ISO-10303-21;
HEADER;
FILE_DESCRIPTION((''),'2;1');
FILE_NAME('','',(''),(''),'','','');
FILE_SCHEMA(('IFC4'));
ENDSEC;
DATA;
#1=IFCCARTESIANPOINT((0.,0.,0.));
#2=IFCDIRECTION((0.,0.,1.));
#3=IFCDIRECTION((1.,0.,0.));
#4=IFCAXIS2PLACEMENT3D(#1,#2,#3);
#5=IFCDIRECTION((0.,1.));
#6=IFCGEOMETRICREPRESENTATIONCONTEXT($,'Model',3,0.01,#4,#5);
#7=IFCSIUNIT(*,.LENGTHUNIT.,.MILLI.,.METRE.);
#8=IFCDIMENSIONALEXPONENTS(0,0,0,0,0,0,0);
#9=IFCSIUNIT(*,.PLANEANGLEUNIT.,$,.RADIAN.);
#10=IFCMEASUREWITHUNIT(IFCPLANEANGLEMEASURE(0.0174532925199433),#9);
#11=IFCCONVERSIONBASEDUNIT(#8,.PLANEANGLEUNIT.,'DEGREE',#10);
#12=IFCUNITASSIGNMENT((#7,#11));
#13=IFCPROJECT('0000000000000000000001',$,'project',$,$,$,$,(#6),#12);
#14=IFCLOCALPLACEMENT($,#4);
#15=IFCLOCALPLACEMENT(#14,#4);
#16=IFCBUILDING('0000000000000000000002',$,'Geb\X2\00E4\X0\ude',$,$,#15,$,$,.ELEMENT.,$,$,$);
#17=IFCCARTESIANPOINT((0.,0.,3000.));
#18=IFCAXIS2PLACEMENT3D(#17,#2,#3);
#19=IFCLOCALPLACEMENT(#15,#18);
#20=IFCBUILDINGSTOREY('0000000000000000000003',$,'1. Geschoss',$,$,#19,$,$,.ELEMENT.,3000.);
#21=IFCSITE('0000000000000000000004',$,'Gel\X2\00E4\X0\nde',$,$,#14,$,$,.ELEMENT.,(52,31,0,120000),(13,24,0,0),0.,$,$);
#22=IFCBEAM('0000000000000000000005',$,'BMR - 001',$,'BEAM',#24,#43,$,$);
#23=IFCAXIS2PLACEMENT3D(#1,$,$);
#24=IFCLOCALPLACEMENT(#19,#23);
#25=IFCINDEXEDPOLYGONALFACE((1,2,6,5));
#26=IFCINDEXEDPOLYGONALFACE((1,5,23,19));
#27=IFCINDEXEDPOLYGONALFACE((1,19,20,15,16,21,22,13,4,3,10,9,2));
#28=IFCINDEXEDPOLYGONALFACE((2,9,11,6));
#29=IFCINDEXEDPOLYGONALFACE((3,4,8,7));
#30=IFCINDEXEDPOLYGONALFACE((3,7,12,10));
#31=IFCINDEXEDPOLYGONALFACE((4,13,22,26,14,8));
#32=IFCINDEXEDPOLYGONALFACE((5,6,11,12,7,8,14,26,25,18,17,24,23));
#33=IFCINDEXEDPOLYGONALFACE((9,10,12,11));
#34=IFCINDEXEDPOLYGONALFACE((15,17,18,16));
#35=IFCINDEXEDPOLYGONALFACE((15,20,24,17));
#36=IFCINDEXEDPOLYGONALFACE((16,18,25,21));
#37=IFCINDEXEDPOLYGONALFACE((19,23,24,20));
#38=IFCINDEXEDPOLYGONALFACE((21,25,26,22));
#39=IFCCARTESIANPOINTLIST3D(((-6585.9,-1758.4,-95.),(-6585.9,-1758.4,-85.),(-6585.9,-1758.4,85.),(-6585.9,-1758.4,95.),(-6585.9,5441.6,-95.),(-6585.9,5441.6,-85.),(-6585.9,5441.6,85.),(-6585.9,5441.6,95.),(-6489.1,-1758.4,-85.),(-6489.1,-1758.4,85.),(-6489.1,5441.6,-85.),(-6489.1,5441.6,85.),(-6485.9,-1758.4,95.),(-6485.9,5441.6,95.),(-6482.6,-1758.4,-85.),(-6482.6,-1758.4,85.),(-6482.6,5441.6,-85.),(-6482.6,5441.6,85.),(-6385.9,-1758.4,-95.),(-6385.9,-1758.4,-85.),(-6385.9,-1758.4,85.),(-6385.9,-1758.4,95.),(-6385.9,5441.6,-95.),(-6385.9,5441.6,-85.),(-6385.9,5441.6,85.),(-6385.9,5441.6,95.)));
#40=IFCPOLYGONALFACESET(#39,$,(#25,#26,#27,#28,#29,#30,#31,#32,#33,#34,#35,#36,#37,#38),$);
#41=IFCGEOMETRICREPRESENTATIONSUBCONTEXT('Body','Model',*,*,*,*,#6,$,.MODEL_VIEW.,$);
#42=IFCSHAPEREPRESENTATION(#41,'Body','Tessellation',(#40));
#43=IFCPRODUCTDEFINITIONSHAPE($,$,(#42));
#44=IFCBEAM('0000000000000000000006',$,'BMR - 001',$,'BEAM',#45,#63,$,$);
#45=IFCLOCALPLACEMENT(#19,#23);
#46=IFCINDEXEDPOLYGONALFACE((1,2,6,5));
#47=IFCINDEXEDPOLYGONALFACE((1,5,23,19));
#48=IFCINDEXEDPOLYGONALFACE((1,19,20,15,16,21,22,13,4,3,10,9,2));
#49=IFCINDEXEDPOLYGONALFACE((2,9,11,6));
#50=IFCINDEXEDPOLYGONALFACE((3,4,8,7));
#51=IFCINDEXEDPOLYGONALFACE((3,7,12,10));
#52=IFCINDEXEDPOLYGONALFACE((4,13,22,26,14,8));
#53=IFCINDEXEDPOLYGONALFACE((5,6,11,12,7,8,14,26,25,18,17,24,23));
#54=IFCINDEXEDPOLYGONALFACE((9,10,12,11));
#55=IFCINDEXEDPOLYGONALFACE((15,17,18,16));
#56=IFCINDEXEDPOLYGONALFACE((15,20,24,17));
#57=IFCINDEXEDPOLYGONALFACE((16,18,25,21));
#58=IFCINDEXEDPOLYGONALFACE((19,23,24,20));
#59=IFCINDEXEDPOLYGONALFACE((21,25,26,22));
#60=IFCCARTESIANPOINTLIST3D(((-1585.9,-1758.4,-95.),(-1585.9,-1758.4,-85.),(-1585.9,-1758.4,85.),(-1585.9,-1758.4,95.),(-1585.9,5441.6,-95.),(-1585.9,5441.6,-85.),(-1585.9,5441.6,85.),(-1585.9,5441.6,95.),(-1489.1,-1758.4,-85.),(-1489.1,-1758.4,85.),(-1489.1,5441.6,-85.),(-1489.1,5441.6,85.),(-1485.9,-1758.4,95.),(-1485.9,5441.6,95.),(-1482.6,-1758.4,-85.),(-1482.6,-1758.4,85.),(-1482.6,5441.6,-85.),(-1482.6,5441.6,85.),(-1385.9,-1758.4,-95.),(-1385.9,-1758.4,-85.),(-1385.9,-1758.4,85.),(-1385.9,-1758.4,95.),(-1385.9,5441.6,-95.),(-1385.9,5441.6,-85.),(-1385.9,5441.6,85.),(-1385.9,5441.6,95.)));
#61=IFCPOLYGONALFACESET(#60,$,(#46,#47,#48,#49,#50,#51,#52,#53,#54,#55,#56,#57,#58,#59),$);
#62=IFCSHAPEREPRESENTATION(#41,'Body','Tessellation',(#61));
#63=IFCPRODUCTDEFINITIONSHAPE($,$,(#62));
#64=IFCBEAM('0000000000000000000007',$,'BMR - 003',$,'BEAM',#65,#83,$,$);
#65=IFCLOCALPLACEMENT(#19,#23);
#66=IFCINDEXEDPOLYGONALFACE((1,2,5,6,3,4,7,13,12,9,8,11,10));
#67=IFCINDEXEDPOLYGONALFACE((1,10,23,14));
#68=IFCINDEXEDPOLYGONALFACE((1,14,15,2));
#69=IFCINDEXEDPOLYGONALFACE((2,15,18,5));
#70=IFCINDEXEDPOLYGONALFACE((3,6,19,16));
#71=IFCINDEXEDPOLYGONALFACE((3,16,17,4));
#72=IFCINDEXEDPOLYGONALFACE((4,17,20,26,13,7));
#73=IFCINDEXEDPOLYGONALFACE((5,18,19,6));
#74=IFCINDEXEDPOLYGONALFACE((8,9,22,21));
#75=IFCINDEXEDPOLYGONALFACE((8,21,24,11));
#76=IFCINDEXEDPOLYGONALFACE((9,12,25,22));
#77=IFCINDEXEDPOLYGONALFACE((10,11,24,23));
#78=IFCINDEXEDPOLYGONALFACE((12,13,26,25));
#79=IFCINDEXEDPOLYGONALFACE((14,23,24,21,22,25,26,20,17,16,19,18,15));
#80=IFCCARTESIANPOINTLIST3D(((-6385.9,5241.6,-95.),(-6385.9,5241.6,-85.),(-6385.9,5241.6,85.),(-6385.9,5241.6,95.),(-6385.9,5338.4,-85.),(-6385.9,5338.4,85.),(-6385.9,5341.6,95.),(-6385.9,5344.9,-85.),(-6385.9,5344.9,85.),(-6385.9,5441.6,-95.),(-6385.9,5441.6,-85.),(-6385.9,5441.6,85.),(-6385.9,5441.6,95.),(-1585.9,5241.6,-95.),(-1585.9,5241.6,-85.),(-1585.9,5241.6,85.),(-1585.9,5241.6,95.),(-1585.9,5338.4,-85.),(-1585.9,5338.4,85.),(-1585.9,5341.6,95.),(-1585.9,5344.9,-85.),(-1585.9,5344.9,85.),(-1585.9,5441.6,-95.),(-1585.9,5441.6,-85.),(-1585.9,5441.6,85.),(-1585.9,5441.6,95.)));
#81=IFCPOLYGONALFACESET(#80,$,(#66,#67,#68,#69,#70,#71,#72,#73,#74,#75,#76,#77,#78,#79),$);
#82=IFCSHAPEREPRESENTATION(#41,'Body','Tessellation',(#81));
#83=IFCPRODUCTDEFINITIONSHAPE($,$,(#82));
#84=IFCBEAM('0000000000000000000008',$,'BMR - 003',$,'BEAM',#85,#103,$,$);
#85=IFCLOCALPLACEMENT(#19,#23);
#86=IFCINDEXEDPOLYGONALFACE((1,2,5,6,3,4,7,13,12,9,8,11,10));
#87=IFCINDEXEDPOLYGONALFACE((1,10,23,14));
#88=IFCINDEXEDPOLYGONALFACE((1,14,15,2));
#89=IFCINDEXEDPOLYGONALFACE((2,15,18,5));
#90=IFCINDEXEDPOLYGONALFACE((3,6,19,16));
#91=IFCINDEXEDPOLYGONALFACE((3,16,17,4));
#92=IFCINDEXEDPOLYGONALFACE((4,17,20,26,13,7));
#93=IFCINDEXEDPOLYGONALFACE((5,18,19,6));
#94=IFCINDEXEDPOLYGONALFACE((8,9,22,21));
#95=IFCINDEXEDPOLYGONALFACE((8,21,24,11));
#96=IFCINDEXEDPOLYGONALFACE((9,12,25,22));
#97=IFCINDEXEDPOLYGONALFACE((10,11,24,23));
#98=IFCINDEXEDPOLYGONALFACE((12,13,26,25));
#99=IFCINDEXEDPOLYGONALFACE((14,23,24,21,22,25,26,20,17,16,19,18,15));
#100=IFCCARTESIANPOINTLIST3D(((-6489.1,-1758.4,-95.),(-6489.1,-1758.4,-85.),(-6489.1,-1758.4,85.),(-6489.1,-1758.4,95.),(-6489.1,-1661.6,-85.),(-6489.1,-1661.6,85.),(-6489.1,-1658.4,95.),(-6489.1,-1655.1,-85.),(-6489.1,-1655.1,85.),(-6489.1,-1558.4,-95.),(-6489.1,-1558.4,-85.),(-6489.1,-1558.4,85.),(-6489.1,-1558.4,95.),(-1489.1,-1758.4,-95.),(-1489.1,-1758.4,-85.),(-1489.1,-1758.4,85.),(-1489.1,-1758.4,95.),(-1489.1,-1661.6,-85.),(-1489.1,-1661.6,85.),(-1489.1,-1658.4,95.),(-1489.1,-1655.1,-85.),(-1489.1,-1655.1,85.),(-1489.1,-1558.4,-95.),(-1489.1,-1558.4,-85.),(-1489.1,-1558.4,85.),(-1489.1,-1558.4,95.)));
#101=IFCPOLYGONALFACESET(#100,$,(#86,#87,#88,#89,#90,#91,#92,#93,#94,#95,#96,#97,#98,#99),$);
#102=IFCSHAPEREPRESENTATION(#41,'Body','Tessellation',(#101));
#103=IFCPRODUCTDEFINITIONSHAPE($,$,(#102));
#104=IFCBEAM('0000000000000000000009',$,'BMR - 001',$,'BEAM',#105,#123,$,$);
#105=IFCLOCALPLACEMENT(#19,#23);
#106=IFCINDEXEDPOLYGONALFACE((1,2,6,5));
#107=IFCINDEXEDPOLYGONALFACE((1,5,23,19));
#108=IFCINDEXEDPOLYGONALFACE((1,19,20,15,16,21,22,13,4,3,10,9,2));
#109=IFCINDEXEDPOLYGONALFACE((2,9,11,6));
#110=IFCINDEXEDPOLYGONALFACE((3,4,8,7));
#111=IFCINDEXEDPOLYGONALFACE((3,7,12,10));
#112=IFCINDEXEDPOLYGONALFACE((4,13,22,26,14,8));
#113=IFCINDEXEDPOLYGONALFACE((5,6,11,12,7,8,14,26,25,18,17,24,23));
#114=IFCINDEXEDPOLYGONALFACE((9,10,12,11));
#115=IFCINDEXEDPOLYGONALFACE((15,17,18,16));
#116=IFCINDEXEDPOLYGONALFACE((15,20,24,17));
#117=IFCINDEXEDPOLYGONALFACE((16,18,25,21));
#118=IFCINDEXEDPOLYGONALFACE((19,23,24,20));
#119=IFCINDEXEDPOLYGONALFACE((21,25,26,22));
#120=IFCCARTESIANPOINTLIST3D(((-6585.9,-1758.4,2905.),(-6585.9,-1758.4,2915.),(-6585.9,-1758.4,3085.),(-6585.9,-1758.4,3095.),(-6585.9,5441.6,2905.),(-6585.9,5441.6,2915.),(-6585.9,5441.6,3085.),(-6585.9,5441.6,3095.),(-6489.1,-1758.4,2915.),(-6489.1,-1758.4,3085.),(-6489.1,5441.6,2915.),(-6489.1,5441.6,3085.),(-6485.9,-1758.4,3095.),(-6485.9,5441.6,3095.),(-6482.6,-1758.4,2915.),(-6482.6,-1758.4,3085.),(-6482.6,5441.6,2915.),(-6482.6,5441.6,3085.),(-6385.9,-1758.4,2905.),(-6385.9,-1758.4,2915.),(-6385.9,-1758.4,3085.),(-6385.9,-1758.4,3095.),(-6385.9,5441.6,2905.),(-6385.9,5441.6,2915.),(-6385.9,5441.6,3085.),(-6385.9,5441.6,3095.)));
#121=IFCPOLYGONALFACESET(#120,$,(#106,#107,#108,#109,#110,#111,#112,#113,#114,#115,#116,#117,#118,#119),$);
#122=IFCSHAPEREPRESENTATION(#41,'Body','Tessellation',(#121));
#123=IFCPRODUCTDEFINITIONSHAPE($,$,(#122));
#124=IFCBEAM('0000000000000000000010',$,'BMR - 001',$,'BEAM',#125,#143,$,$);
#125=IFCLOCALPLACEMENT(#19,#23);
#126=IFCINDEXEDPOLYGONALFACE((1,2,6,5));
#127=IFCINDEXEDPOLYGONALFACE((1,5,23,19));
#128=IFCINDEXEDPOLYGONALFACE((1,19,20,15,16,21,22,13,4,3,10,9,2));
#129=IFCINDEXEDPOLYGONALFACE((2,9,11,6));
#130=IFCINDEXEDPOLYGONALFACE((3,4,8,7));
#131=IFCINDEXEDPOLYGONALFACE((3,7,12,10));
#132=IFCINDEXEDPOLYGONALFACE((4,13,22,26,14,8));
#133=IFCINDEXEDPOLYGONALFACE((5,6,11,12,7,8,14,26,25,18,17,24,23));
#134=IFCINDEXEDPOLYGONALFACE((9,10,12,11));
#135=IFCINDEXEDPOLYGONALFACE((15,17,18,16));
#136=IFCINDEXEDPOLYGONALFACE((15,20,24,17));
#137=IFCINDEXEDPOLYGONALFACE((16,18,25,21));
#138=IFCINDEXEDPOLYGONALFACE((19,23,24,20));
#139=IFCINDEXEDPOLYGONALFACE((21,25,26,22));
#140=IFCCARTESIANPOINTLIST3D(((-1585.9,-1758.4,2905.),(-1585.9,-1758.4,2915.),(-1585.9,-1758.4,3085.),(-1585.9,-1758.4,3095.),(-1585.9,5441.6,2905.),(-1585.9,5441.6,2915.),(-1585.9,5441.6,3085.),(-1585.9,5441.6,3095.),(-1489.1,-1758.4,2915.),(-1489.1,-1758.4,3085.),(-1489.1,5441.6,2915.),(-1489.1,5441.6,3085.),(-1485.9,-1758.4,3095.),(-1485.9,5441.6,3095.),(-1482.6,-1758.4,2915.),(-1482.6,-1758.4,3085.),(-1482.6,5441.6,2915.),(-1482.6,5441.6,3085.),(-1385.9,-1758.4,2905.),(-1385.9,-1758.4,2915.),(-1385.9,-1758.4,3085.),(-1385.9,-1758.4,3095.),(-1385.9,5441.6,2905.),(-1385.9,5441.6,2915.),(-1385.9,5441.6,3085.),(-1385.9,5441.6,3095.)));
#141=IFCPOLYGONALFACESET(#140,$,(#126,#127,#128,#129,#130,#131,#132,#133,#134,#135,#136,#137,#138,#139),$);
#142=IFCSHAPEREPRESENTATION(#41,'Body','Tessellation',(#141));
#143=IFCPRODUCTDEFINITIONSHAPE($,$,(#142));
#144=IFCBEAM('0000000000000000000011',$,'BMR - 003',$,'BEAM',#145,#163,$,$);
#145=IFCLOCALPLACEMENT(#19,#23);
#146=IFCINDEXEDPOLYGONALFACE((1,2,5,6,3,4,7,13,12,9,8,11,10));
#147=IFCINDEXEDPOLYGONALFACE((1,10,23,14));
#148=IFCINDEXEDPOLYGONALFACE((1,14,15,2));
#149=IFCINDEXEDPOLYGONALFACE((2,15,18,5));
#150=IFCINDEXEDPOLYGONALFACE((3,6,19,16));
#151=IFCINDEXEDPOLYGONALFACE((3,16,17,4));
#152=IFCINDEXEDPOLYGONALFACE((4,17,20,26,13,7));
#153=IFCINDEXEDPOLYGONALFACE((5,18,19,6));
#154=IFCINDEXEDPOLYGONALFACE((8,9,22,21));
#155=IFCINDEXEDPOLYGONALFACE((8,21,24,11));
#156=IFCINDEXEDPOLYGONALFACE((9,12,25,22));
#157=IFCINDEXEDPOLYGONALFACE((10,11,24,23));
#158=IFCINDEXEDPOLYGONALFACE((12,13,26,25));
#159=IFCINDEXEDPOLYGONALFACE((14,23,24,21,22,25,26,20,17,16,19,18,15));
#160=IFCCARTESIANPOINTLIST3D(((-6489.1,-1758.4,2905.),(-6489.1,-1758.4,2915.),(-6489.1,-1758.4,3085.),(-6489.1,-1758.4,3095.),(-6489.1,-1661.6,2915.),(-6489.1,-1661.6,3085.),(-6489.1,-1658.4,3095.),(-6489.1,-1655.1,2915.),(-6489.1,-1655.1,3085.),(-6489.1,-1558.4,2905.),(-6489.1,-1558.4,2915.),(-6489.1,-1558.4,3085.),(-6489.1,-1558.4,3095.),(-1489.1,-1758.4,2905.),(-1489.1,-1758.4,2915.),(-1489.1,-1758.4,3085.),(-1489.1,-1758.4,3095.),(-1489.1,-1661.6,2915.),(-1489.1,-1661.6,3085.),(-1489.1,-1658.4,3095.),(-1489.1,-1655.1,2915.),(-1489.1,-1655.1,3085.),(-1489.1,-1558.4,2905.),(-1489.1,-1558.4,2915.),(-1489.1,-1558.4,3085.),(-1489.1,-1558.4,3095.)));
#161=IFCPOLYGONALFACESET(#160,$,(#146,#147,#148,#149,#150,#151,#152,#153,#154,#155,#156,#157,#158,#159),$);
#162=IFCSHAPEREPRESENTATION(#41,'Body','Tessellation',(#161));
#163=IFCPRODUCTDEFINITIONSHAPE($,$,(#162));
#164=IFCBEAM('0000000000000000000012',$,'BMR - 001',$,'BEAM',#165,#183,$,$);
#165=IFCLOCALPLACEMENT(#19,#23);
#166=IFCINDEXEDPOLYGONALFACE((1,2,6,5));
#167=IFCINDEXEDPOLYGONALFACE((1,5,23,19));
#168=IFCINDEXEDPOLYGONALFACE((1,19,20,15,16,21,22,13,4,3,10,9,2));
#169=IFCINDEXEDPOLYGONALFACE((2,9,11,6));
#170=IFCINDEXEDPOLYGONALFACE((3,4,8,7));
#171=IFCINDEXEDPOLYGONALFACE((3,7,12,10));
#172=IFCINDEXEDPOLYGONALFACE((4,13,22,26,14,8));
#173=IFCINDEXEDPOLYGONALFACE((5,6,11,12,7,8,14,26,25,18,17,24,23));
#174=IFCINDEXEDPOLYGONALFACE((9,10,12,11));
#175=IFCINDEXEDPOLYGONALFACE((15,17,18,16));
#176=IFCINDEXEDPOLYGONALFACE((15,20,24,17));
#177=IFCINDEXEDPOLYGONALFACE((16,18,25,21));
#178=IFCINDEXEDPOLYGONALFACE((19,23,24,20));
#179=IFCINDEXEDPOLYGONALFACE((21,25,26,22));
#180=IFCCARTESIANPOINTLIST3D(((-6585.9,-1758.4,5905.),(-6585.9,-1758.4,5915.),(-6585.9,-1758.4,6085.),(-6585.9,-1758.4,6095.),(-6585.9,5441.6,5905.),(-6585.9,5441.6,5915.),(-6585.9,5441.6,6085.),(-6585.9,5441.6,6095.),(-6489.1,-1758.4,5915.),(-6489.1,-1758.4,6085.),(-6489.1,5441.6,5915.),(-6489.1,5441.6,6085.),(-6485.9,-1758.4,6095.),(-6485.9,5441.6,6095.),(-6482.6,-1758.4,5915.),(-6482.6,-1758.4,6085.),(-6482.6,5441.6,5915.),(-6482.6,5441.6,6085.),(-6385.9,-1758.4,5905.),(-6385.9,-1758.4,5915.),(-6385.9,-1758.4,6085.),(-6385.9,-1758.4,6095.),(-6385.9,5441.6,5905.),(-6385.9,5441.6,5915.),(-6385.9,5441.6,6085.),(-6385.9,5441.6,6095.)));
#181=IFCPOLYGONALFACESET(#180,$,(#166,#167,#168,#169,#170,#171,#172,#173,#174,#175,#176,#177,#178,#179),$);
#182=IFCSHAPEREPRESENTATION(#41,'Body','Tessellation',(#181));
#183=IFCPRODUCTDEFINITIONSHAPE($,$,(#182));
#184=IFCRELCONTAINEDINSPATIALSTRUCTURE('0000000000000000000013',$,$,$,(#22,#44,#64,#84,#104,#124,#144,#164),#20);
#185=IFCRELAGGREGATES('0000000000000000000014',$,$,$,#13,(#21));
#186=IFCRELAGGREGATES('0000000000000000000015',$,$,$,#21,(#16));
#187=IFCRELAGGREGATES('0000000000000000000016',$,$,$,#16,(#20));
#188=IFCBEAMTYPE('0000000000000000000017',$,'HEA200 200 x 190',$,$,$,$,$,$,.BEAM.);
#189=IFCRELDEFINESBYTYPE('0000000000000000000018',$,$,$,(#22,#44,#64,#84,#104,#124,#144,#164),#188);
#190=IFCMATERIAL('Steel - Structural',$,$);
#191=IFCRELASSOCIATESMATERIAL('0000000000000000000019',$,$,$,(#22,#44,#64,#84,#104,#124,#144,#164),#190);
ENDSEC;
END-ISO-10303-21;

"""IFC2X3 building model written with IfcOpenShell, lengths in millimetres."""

from ifc_helpers import new_model, entity, si_unit, converted_unit, direction, frame, origin_with_axes, place, context, subcontext, project, spatial, polyline, outline, extrude, material, type_object, element, save


model = new_model("IFC2X3")

# Units and contexts
model_context = context("Model", 3, precision=0.01, world=origin_with_axes(), true_north=direction((0.0, 1.0)))
body_context = subcontext(model_context, "Body", "Model", "MODEL_VIEW")
ifc_project = project(units=[si_unit("LENGTHUNIT", "METRE", prefix="MILLI"), converted_unit("PLANEANGLEUNIT", "DEGREE", entity("IfcPlaneAngleMeasure", 0.0174532925199433), si_unit("PLANEANGLEUNIT", "RADIAN"), dimensions=[0, 0, 0, 0, 0, 0, 0])], contexts=[model_context])

# Site, building, storey
site_placement = place(None, origin_with_axes())
site = spatial("IfcSite", under=ifc_project, at=site_placement, Name="Gelände", CompositionType="ELEMENT", RefLatitude=(52, 31, 0, 120000), RefLongitude=(13, 24, 0, 0), RefElevation=0.0)
building_placement = place(site_placement, origin_with_axes())
building = spatial("IfcBuilding", under=site, at=building_placement, Name="Gebäude", CompositionType="ELEMENT")
storey_placement = place(building_placement, frame((0.0, 0.0, 3000.0), z_axis=(0.0, 0.0, 1.0), x_axis=(1.0, 0.0, 0.0)))
storey = spatial("IfcBuildingStorey", under=building, at=storey_placement, Name="1. Geschoss", CompositionType="ELEMENT", Elevation=3000.0)

# Beams
ifc_material = material(Name="Steel - Structural")
beam_type = type_object("IfcBeamType", Name="HEA200 200 x 190", PredefinedType="BEAM")
for number, where, z_axis, x_axis, name in (
    (1, (-6485.9, -1758.4, 0.0), (0.0, 0.0, 1.0), (1.0, 0.0, 0.0), "BMR - 001"),
    (2, (-1485.9, -1758.4, 0.0), (0.0, 0.0, 1.0), (1.0, 0.0, 0.0), "BMR - 001"),
):
    element("IfcBeam", number, at=place(storey_placement, frame(where, z_axis=z_axis, x_axis=x_axis)), inside=storey, type_object=beam_type, material=ifc_material, Name=name, ObjectType="BEAM", context=body_context, shape_type="SweptSolid", body=[
        extrude(outline(polyline([(0.0, 95.0), (-100.0, 95.0), (-100.0, 85.0), (-3.2, 85.0), (-3.2, -85.0), (-100.0, -85.0), (-100.0, -95.0), (100.0, -95.0), (100.0, -85.0), (3.2, -85.0), (3.2, 85.0), (100.0, 85.0), (100.0, 95.0), (0.0, 95.0)])), frame((0.0, 7200.0, 0.0), z_axis=(0.0, -1.0, 0.0), x_axis=(1.0, 0.0, 0.0)), (0.0, 0.0, 1.0), 7200.0),
    ])
beam_1_placement = place(storey_placement, frame((-6385.9, 5341.6, 0.0), z_axis=(0.0, 0.0, 1.0), x_axis=(0.0, -1.0, 0.0)))
element("IfcBeam", 3, at=beam_1_placement, inside=storey, type_object=beam_type, material=ifc_material, Name="BMR - 003", ObjectType="BEAM", context=body_context, shape_type="SweptSolid", body=[
    extrude(outline(polyline([(0.0, 95.0), (-100.0, 95.0), (-100.0, 85.0), (-3.2, 85.0), (-3.2, -85.0), (-100.0, -85.0), (-100.0, -95.0), (100.0, -95.0), (100.0, -85.0), (3.2, -85.0), (3.2, 85.0), (100.0, 85.0), (100.0, 95.0), (0.0, 95.0)])), frame((0.0, 4800.0, 0.0), z_axis=(0.0, -1.0, 0.0), x_axis=(1.0, 0.0, 0.0)), (0.0, 0.0, 1.0), 4800.0),
])
beam_2_placement = place(storey_placement, frame((-6489.1, -1658.4, 0.0), z_axis=(0.0, 0.0, 1.0), x_axis=(0.0, -1.0, 0.0)))
element("IfcBeam", 4, at=beam_2_placement, inside=storey, type_object=beam_type, material=ifc_material, Name="BMR - 003", ObjectType="BEAM", context=body_context, shape_type="SweptSolid", body=[
    extrude(outline(polyline([(0.0, 95.0), (-100.0, 95.0), (-100.0, 85.0), (-3.2, 85.0), (-3.2, -85.0), (-100.0, -85.0), (-100.0, -95.0), (100.0, -95.0), (100.0, -85.0), (3.2, -85.0), (3.2, 85.0), (100.0, 85.0), (100.0, 95.0), (0.0, 95.0)])), frame((0.0, 5000.0, 0.0), z_axis=(0.0, -1.0, 0.0), x_axis=(1.0, 0.0, 0.0)), (0.0, 0.0, 1.0), 5000.0),
])
for number, where, z_axis, x_axis, name in (
    (5, (-6485.9, -1758.4, 3000.0), (0.0, 0.0, 1.0), (1.0, 0.0, 0.0), "BMR - 001"),
    (6, (-1485.9, -1758.4, 3000.0), (0.0, 0.0, 1.0), (1.0, 0.0, 0.0), "BMR - 001"),
):
    element("IfcBeam", number, at=place(storey_placement, frame(where, z_axis=z_axis, x_axis=x_axis)), inside=storey, type_object=beam_type, material=ifc_material, Name=name, ObjectType="BEAM", context=body_context, shape_type="SweptSolid", body=[
        extrude(outline(polyline([(0.0, 95.0), (-100.0, 95.0), (-100.0, 85.0), (-3.2, 85.0), (-3.2, -85.0), (-100.0, -85.0), (-100.0, -95.0), (100.0, -95.0), (100.0, -85.0), (3.2, -85.0), (3.2, 85.0), (100.0, 85.0), (100.0, 95.0), (0.0, 95.0)])), frame((0.0, 7200.0, 0.0), z_axis=(0.0, -1.0, 0.0), x_axis=(1.0, 0.0, 0.0)), (0.0, 0.0, 1.0), 7200.0),
    ])
beam_3_placement = place(storey_placement, frame((-6489.1, -1658.4, 3000.0), z_axis=(0.0, 0.0, 1.0), x_axis=(0.0, -1.0, 0.0)))
element("IfcBeam", 7, at=beam_3_placement, inside=storey, type_object=beam_type, material=ifc_material, Name="BMR - 003", ObjectType="BEAM", context=body_context, shape_type="SweptSolid", body=[
    extrude(outline(polyline([(0.0, 95.0), (-100.0, 95.0), (-100.0, 85.0), (-3.2, 85.0), (-3.2, -85.0), (-100.0, -85.0), (-100.0, -95.0), (100.0, -95.0), (100.0, -85.0), (3.2, -85.0), (3.2, 85.0), (100.0, 85.0), (100.0, 95.0), (0.0, 95.0)])), frame((0.0, 5000.0, 0.0), z_axis=(0.0, -1.0, 0.0), x_axis=(1.0, 0.0, 0.0)), (0.0, 0.0, 1.0), 5000.0),
])
for number, where, z_axis, x_axis, name in (
    (8, (-6485.9, -1758.4, 6000.0), (0.0, 0.0, 1.0), (1.0, 0.0, 0.0), "BMR - 001"),
):
    element("IfcBeam", number, at=place(storey_placement, frame(where, z_axis=z_axis, x_axis=x_axis)), inside=storey, type_object=beam_type, material=ifc_material, Name=name, ObjectType="BEAM", context=body_context, shape_type="SweptSolid", body=[
        extrude(outline(polyline([(0.0, 95.0), (-100.0, 95.0), (-100.0, 85.0), (-3.2, 85.0), (-3.2, -85.0), (-100.0, -85.0), (-100.0, -95.0), (100.0, -95.0), (100.0, -85.0), (3.2, -85.0), (3.2, 85.0), (100.0, 85.0), (100.0, 95.0), (0.0, 95.0)])), frame((0.0, 7200.0, 0.0), z_axis=(0.0, -1.0, 0.0), x_axis=(1.0, 0.0, 0.0)), (0.0, 0.0, 1.0), 7200.0),
    ])

save(model, "model.ifc")
